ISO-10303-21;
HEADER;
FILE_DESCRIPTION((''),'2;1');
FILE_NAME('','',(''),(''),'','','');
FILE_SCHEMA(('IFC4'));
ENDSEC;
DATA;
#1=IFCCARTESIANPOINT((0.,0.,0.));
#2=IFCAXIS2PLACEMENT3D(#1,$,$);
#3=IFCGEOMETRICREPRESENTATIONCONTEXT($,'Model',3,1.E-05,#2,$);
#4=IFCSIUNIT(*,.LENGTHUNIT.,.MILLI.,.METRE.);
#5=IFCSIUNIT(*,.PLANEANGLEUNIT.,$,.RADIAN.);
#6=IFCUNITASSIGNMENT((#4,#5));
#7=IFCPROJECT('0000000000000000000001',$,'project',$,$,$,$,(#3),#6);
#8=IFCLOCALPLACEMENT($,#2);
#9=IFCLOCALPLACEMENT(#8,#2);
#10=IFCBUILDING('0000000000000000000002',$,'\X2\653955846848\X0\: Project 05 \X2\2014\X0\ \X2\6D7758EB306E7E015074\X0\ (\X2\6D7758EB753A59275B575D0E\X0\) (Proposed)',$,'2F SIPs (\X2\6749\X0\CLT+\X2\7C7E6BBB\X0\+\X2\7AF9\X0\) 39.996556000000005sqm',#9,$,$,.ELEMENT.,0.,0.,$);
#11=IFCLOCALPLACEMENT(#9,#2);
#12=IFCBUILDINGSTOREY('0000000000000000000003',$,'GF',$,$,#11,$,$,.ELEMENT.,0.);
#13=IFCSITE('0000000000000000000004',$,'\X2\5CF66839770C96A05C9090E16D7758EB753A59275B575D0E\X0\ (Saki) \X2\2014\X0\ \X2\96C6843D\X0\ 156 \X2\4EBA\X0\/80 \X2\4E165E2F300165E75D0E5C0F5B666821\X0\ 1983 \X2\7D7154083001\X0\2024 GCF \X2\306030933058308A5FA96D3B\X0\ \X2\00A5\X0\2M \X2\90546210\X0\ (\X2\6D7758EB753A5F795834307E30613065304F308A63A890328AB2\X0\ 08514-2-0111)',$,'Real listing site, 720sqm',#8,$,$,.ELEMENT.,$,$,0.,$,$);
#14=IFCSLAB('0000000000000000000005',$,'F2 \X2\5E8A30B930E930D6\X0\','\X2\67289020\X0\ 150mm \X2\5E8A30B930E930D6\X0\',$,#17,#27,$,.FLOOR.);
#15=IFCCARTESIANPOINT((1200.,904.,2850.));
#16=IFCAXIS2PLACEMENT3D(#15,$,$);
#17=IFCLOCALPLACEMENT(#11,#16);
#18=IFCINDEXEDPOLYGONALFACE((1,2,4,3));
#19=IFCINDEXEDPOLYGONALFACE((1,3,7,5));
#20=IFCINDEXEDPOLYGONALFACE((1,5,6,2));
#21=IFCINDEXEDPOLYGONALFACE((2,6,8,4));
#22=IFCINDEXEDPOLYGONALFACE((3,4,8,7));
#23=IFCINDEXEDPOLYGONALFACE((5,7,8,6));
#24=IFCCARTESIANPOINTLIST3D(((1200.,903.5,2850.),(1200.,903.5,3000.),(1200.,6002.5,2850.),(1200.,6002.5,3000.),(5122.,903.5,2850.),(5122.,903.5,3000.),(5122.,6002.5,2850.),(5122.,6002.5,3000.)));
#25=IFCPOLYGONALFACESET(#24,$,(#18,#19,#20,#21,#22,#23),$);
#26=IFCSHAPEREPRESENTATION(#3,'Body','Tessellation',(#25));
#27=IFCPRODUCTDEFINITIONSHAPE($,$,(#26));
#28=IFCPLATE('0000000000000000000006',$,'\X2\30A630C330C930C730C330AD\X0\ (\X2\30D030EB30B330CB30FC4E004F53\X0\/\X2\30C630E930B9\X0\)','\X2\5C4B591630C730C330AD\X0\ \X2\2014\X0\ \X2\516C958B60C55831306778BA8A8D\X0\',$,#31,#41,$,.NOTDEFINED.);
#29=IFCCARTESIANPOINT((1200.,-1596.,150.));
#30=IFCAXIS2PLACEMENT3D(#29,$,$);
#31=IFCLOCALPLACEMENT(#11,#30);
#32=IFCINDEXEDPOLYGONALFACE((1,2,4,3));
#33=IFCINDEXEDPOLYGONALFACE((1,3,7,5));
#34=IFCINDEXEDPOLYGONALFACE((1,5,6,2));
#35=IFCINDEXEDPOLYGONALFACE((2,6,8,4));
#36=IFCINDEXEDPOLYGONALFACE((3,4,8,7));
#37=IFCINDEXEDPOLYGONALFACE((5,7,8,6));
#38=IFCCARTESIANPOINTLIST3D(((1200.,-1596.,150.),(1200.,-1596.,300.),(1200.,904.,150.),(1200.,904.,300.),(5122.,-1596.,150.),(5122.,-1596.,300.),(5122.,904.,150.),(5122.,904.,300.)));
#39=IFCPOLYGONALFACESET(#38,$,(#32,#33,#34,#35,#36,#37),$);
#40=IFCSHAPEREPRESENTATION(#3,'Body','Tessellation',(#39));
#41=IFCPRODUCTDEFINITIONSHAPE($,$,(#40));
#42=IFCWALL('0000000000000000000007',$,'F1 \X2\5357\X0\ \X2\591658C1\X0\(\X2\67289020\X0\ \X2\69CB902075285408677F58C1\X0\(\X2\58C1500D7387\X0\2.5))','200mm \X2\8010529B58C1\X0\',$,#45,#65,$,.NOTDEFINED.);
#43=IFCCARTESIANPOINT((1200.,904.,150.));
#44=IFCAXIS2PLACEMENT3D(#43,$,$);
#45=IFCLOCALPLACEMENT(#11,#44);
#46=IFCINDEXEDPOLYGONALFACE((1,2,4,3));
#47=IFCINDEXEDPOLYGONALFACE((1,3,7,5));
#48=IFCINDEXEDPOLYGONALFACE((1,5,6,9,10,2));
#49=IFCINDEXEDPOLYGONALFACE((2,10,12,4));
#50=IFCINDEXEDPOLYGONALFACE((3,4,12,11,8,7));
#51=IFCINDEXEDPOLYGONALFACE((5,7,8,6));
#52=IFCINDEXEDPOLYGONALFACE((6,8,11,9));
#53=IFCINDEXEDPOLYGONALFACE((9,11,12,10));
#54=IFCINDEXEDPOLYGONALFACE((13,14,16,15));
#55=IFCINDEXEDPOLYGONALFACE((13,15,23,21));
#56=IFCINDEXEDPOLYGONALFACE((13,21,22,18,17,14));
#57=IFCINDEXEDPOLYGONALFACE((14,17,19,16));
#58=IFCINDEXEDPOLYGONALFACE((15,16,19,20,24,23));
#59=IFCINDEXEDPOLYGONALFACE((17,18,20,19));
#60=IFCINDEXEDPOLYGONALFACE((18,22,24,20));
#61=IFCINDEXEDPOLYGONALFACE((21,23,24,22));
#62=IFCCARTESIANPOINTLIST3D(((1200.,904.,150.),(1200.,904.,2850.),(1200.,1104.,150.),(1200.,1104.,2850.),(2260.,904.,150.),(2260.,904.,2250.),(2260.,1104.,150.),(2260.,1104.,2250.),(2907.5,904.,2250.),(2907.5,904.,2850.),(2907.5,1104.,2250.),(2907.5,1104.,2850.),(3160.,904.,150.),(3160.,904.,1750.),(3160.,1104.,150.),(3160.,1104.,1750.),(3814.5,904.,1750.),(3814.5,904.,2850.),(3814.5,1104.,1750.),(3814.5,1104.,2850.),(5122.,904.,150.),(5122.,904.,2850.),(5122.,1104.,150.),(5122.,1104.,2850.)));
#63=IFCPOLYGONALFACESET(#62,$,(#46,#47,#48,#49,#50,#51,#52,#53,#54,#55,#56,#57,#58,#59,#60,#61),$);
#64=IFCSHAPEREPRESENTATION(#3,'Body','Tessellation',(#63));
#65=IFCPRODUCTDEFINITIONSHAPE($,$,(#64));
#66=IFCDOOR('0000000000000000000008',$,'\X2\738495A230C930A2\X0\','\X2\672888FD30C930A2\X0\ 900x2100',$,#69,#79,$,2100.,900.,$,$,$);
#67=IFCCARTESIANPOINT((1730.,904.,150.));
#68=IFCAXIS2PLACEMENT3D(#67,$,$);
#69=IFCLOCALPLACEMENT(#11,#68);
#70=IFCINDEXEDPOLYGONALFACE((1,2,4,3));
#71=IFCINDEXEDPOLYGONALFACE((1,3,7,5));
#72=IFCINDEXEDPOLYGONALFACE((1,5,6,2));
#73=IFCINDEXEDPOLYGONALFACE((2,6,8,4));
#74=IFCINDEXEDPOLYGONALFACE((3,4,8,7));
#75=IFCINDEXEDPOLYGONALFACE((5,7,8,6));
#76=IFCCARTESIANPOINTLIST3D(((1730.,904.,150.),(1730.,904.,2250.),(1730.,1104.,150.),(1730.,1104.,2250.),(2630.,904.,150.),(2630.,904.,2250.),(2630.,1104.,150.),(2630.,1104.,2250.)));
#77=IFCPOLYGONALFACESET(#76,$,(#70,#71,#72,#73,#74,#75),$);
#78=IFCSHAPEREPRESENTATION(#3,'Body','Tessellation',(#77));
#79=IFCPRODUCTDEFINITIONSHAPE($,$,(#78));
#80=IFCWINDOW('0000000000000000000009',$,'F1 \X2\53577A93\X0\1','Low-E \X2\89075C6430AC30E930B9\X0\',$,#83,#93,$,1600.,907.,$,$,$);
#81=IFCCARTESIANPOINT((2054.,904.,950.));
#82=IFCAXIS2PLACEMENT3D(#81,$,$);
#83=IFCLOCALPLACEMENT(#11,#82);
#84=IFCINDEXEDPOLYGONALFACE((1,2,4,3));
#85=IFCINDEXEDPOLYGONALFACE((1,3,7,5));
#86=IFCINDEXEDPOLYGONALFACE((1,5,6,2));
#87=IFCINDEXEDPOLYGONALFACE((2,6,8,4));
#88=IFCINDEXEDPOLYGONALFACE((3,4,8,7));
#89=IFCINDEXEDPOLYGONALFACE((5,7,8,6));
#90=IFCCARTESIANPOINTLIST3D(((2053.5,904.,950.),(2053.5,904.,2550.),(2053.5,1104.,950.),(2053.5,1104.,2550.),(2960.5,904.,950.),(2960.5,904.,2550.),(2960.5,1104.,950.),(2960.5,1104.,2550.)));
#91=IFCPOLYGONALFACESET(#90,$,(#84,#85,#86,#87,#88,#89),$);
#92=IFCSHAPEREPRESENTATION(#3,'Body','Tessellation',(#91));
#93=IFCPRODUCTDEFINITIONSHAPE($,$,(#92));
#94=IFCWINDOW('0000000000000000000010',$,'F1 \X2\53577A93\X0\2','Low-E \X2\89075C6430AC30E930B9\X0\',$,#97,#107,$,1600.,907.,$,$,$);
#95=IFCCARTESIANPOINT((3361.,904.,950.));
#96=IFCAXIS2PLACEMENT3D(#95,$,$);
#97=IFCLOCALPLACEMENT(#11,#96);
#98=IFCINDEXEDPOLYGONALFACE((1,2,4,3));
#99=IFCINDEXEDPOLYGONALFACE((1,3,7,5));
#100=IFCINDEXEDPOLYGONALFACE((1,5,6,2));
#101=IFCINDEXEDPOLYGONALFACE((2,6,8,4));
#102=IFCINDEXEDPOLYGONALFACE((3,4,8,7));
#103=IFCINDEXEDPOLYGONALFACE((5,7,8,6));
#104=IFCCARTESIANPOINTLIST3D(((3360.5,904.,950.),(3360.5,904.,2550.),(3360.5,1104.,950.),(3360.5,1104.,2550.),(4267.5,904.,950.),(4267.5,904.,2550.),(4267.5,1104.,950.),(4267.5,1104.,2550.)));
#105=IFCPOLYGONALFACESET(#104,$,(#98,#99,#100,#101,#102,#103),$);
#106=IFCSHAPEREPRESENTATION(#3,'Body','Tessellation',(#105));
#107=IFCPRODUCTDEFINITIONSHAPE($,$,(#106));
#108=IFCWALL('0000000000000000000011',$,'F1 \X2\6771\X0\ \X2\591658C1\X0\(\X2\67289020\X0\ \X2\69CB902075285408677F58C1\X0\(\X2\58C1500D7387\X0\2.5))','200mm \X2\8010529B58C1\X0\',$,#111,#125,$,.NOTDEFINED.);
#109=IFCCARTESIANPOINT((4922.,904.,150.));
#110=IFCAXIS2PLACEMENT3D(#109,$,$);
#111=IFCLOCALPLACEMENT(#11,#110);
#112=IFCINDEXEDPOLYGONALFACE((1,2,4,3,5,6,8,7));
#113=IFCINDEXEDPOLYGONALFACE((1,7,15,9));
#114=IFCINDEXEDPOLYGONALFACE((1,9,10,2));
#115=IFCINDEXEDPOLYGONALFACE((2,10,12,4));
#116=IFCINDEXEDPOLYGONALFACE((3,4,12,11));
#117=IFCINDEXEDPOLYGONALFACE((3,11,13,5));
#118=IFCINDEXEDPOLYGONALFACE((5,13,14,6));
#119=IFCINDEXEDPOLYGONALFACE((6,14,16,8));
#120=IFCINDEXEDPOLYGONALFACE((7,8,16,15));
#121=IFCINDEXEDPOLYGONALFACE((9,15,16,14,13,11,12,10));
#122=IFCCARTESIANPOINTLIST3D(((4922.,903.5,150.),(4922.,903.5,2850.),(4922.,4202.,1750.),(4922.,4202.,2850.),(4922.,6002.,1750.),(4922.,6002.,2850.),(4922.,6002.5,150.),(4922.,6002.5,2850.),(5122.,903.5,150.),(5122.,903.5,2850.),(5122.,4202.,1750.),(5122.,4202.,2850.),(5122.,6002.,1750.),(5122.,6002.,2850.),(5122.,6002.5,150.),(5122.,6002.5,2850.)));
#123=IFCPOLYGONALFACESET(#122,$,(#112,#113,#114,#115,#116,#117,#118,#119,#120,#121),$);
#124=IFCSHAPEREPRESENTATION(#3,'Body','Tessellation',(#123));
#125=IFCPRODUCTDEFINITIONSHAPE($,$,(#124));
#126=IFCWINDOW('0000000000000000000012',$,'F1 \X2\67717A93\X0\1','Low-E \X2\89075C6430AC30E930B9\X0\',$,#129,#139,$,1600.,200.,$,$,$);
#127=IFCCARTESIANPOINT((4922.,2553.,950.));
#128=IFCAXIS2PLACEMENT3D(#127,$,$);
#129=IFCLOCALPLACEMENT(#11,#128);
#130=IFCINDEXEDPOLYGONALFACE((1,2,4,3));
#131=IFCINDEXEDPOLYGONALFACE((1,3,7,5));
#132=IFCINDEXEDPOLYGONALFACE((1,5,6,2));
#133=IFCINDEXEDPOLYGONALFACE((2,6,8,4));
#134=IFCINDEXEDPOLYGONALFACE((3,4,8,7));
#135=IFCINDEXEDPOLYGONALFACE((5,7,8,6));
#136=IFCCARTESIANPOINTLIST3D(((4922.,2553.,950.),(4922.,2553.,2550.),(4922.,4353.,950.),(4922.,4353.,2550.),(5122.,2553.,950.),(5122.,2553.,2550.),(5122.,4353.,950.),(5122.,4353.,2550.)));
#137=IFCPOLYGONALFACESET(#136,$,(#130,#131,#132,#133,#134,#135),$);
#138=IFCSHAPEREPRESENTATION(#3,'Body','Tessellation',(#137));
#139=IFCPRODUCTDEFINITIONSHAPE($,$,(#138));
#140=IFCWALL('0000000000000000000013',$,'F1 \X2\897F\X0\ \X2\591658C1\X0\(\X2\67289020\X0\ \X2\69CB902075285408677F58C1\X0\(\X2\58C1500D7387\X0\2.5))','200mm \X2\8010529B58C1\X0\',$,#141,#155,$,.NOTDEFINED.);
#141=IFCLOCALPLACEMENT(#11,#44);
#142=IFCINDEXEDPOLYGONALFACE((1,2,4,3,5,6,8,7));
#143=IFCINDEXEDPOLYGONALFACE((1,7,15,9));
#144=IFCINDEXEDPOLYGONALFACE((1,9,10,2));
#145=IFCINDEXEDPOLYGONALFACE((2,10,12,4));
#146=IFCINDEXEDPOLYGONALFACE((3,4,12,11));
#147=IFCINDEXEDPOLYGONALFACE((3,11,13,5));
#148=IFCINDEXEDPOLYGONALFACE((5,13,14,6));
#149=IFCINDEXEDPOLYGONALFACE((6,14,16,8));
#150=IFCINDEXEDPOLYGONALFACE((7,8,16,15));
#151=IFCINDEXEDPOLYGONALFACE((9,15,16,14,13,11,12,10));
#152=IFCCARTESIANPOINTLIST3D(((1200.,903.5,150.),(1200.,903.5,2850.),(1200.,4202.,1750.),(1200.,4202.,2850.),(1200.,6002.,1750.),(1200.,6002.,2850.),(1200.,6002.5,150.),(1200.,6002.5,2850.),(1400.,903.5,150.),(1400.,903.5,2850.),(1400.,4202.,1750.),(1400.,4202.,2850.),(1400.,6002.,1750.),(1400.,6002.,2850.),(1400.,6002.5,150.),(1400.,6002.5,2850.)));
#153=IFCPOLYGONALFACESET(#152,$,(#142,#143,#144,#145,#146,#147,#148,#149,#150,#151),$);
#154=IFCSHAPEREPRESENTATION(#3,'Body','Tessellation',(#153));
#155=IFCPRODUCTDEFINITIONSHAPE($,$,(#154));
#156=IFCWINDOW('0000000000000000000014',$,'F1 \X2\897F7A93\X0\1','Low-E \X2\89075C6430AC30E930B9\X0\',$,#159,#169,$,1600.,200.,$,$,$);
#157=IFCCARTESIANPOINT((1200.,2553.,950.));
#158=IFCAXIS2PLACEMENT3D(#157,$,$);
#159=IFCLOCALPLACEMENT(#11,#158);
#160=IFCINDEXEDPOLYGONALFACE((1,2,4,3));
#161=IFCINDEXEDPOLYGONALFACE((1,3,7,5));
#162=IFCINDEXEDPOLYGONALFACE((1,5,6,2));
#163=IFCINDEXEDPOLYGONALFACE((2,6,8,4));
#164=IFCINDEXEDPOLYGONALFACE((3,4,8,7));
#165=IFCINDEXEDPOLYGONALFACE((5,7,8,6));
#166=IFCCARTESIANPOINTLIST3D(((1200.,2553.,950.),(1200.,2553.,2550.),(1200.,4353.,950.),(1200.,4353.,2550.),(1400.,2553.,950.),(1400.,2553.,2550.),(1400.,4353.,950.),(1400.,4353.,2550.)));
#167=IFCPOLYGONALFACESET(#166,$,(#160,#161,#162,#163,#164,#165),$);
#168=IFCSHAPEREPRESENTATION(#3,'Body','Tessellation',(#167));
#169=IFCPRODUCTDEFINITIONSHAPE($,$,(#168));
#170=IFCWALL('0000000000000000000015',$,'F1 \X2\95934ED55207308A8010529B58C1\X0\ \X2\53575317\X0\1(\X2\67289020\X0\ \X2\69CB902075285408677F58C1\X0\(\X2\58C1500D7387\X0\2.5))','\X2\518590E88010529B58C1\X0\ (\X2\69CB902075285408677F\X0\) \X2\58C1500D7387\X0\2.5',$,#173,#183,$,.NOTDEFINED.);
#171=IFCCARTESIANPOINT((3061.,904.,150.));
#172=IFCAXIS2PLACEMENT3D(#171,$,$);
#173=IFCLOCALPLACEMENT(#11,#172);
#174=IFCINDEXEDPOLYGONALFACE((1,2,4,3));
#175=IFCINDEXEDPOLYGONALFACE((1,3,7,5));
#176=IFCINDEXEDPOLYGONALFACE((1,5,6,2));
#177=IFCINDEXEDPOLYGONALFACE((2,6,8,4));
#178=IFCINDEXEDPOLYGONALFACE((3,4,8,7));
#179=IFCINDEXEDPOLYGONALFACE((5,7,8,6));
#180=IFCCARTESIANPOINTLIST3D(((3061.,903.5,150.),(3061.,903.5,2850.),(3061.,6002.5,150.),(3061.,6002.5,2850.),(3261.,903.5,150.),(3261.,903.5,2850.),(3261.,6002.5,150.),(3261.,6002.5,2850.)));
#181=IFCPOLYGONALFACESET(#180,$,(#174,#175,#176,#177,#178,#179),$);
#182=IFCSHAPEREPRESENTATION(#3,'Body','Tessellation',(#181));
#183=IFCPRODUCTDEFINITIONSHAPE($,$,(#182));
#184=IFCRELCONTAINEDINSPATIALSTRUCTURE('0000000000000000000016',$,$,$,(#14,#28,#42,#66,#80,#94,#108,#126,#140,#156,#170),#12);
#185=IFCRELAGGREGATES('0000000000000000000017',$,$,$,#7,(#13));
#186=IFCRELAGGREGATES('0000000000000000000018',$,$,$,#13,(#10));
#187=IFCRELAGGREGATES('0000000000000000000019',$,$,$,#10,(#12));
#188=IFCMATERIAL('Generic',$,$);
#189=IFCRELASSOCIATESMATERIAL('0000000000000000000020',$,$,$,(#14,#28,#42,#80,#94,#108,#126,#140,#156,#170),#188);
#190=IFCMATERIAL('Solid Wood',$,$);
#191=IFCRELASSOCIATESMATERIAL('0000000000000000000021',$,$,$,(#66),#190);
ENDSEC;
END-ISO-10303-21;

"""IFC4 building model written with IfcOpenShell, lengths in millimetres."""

from ifc_helpers import new_model, si_unit, frame, frame_2d, origin, place, context, project, spatial, rectangle, extrude, material, element, fill, save


model = new_model("IFC4")

# Units and contexts
model_context = context("Model", 3, precision=1e-05, world=origin())
ifc_project = project(units=[si_unit("LENGTHUNIT", "METRE", prefix="MILLI"), si_unit("PLANEANGLEUNIT", "RADIAN")], contexts=[model_context])

# Site, building, storey
site_placement = place(None, origin())
site = spatial("IfcSite", under=ifc_project, at=site_placement, Name="島根県隠岐郡海士町大字崎 (Saki) — 集落 156 人/80 世帯、旧崎小学校 1983 統合、2024 GCF だんじり復活 ¥2M 達成 (海士町役場まちづくり推進課 08514-2-0111)", ObjectType="Real listing site, 720sqm", CompositionType="ELEMENT", RefElevation=0.0)
building_placement = place(site_placement, origin())
building = spatial("IfcBuilding", under=site, at=building_placement, Name="改善案: Project 05 — 海士の縁側 (海士町大字崎) (Proposed)", ObjectType="2F SIPs (杉CLT+籾殻+竹) 39.996556000000005sqm", CompositionType="ELEMENT", ElevationOfRefHeight=0.0, ElevationOfTerrain=0.0)
storey_placement = place(building_placement, origin())
storey = spatial("IfcBuildingStorey", under=building, at=storey_placement, Name="GF", CompositionType="ELEMENT", Elevation=0.0)

# Slab
ifc_material_1 = material(Name="Generic")
slab_1_placement = place(storey_placement, frame((1200.0, 904.0, 2850.0)))
element("IfcSlab", 1, at=slab_1_placement, inside=storey, material=ifc_material_1, Name="F2 床スラブ", Description="木造 150mm 床スラブ", PredefinedType="FLOOR", context=model_context, shape_type="SweptSolid", body=[
    extrude(rectangle(XDim=3922.0, YDim=5099.0, at=frame_2d((1961.0, 2549.0))), frame((1200.0, 904.0, 2850.0)), (0.0, 0.0, 1.0), 150.0),
])

# Plate
plate_placement = place(storey_placement, frame((1200.0, -1596.0, 150.0)))
element("IfcPlate", 2, at=plate_placement, inside=storey, material=ifc_material_1, Name="ウッドデッキ (バルコニー一体/テラス)", Description="屋外デッキ — 公開情報で確認", PredefinedType="NOTDEFINED", context=model_context, shape_type="SweptSolid", body=[
    extrude(rectangle(XDim=3922.0, YDim=2500.0, at=frame_2d((1961.0, 1250.0))), frame((1200.0, -1596.0, 150.0)), (0.0, 0.0, 1.0), 150.0),
])

# Wall, openings, door, windows
wall_1_placement = place(storey_placement, frame((1200.0, 904.0, 150.0)))
wall_1 = element("IfcWall", 3, at=wall_1_placement, inside=storey, material=ifc_material_1, Name="F1 南 外壁(木造 構造用合板壁(壁倍率2.5))", Description="200mm 耐力壁", PredefinedType="NOTDEFINED", context=model_context, shape_type="SweptSolid", body=[
    extrude(rectangle(XDim=3922.0, YDim=200.0, at=frame_2d((1961.0, 100.0))), frame((1200.0, 904.0, 150.0)), (0.0, 0.0, 1.0), 2700.0),
])
opening_1_placement = place(storey_placement, frame((1730.0, 904.0, 150.0)))
opening_1 = element("IfcOpeningElement", 4, at=opening_1_placement, cuts=wall_1, PredefinedType="NOTDEFINED", context=model_context, shape_type="SweptSolid", body=[
    extrude(rectangle(XDim=900.0, YDim=200.0, at=frame_2d((450.0, 100.0))), frame((1730.0, 904.0, 150.0)), (0.0, 0.0, 1.0), 2100.0),
])
opening_2_placement = place(storey_placement, frame((2054.0, 904.0, 950.0)))
opening_2 = element("IfcOpeningElement", 5, at=opening_2_placement, cuts=wall_1, PredefinedType="NOTDEFINED", context=model_context, shape_type="SweptSolid", body=[
    extrude(rectangle(XDim=907.0, YDim=200.0, at=frame_2d((453.0, 100.0))), frame((2054.0, 904.0, 950.0)), (0.0, 0.0, 1.0), 1600.0),
])
opening_3_placement = place(storey_placement, frame((3361.0, 904.0, 950.0)))
opening_3 = element("IfcOpeningElement", 6, at=opening_3_placement, cuts=wall_1, PredefinedType="NOTDEFINED", context=model_context, shape_type="SweptSolid", body=[
    extrude(rectangle(XDim=907.0, YDim=200.0, at=frame_2d((453.0, 100.0))), frame((3361.0, 904.0, 950.0)), (0.0, 0.0, 1.0), 1600.0),
])
ifc_material_2 = material(Name="Solid Wood")
door_placement = place(storey_placement, frame((1730.0, 904.0, 150.0)))
door = element("IfcDoor", 7, at=door_placement, inside=storey, material=ifc_material_2, Name="玄関ドア", Description="木製ドア 900x2100", OverallHeight=2100.0, OverallWidth=900.0, context=model_context, shape_type="SweptSolid", body=[
    extrude(rectangle(XDim=900.0, YDim=200.0, at=frame_2d((450.0, 100.0))), frame((1730.0, 904.0, 150.0)), (0.0, 0.0, 1.0), 2100.0),
])
fill(opening_1, door)
window_1_placement = place(storey_placement, frame((2054.0, 904.0, 950.0)))
window_1 = element("IfcWindow", 8, at=window_1_placement, inside=storey, material=ifc_material_1, Name="F1 南窓1", Description="Low-E 複層ガラス", OverallHeight=1600.0, OverallWidth=907.0, context=model_context, shape_type="SweptSolid", body=[
    extrude(rectangle(XDim=907.0, YDim=200.0, at=frame_2d((453.0, 100.0))), frame((2054.0, 904.0, 950.0)), (0.0, 0.0, 1.0), 1600.0),
])
fill(opening_2, window_1)
window_2_placement = place(storey_placement, frame((3361.0, 904.0, 950.0)))
window_2 = element("IfcWindow", 9, at=window_2_placement, inside=storey, material=ifc_material_1, Name="F1 南窓2", Description="Low-E 複層ガラス", OverallHeight=1600.0, OverallWidth=907.0, context=model_context, shape_type="SweptSolid", body=[
    extrude(rectangle(XDim=907.0, YDim=200.0, at=frame_2d((453.0, 100.0))), frame((3361.0, 904.0, 950.0)), (0.0, 0.0, 1.0), 1600.0),
])
fill(opening_3, window_2)

# Walls, openings, windows
wall_2_placement = place(storey_placement, frame((4922.0, 904.0, 150.0)))
wall_2 = element("IfcWall", 10, at=wall_2_placement, inside=storey, material=ifc_material_1, Name="F1 東 外壁(木造 構造用合板壁(壁倍率2.5))", Description="200mm 耐力壁", PredefinedType="NOTDEFINED", context=model_context, shape_type="SweptSolid", body=[
    extrude(rectangle(XDim=200.0, YDim=5099.0, at=frame_2d((100.0, 2549.0))), frame((4922.0, 904.0, 150.0)), (0.0, 0.0, 1.0), 2700.0),
])
opening_4_placement = place(storey_placement, frame((4922.0, 2553.0, 950.0)))
opening_4 = element("IfcOpeningElement", 11, at=opening_4_placement, cuts=wall_2, PredefinedType="NOTDEFINED", context=model_context, shape_type="SweptSolid", body=[
    extrude(rectangle(XDim=200.0, YDim=1800.0, at=frame_2d((100.0, 900.0))), frame((4922.0, 2553.0, 950.0)), (0.0, 0.0, 1.0), 1600.0),
])
window_3_placement = place(storey_placement, frame((4922.0, 2553.0, 950.0)))
window_3 = element("IfcWindow", 12, at=window_3_placement, inside=storey, material=ifc_material_1, Name="F1 東窓1", Description="Low-E 複層ガラス", OverallHeight=1600.0, OverallWidth=200.0, context=model_context, shape_type="SweptSolid", body=[
    extrude(rectangle(XDim=200.0, YDim=1800.0, at=frame_2d((100.0, 900.0))), frame((4922.0, 2553.0, 950.0)), (0.0, 0.0, 1.0), 1600.0),
])
fill(opening_4, window_3)
wall_3_placement = place(storey_placement, frame((1200.0, 904.0, 150.0)))
wall_3 = element("IfcWall", 13, at=wall_3_placement, inside=storey, material=ifc_material_1, Name="F1 西 外壁(木造 構造用合板壁(壁倍率2.5))", Description="200mm 耐力壁", PredefinedType="NOTDEFINED", context=model_context, shape_type="SweptSolid", body=[
    extrude(rectangle(XDim=200.0, YDim=5099.0, at=frame_2d((100.0, 2549.0))), frame((1200.0, 904.0, 150.0)), (0.0, 0.0, 1.0), 2700.0),
])
opening_5_placement = place(storey_placement, frame((1200.0, 2553.0, 950.0)))
opening_5 = element("IfcOpeningElement", 14, at=opening_5_placement, cuts=wall_3, PredefinedType="NOTDEFINED", context=model_context, shape_type="SweptSolid", body=[
    extrude(rectangle(XDim=200.0, YDim=1800.0, at=frame_2d((100.0, 900.0))), frame((1200.0, 2553.0, 950.0)), (0.0, 0.0, 1.0), 1600.0),
])
window_4_placement = place(storey_placement, frame((1200.0, 2553.0, 950.0)))
window_4 = element("IfcWindow", 15, at=window_4_placement, inside=storey, material=ifc_material_1, Name="F1 西窓1", Description="Low-E 複層ガラス", OverallHeight=1600.0, OverallWidth=200.0, context=model_context, shape_type="SweptSolid", body=[
    extrude(rectangle(XDim=200.0, YDim=1800.0, at=frame_2d((100.0, 900.0))), frame((1200.0, 2553.0, 950.0)), (0.0, 0.0, 1.0), 1600.0),
])
fill(opening_5, window_4)

# Wall
wall_4_placement = place(storey_placement, frame((3061.0, 904.0, 150.0)))
element("IfcWall", 16, at=wall_4_placement, inside=storey, material=ifc_material_1, Name="F1 間仕切り耐力壁 南北1(木造 構造用合板壁(壁倍率2.5))", Description="内部耐力壁 (構造用合板) 壁倍率2.5", PredefinedType="NOTDEFINED", context=model_context, shape_type="SweptSolid", body=[
    extrude(rectangle(XDim=200.0, YDim=5099.0, at=frame_2d((100.0, 2549.0))), frame((3061.0, 904.0, 150.0)), (0.0, 0.0, 1.0), 2700.0),
])

save(model, "model.ifc")
